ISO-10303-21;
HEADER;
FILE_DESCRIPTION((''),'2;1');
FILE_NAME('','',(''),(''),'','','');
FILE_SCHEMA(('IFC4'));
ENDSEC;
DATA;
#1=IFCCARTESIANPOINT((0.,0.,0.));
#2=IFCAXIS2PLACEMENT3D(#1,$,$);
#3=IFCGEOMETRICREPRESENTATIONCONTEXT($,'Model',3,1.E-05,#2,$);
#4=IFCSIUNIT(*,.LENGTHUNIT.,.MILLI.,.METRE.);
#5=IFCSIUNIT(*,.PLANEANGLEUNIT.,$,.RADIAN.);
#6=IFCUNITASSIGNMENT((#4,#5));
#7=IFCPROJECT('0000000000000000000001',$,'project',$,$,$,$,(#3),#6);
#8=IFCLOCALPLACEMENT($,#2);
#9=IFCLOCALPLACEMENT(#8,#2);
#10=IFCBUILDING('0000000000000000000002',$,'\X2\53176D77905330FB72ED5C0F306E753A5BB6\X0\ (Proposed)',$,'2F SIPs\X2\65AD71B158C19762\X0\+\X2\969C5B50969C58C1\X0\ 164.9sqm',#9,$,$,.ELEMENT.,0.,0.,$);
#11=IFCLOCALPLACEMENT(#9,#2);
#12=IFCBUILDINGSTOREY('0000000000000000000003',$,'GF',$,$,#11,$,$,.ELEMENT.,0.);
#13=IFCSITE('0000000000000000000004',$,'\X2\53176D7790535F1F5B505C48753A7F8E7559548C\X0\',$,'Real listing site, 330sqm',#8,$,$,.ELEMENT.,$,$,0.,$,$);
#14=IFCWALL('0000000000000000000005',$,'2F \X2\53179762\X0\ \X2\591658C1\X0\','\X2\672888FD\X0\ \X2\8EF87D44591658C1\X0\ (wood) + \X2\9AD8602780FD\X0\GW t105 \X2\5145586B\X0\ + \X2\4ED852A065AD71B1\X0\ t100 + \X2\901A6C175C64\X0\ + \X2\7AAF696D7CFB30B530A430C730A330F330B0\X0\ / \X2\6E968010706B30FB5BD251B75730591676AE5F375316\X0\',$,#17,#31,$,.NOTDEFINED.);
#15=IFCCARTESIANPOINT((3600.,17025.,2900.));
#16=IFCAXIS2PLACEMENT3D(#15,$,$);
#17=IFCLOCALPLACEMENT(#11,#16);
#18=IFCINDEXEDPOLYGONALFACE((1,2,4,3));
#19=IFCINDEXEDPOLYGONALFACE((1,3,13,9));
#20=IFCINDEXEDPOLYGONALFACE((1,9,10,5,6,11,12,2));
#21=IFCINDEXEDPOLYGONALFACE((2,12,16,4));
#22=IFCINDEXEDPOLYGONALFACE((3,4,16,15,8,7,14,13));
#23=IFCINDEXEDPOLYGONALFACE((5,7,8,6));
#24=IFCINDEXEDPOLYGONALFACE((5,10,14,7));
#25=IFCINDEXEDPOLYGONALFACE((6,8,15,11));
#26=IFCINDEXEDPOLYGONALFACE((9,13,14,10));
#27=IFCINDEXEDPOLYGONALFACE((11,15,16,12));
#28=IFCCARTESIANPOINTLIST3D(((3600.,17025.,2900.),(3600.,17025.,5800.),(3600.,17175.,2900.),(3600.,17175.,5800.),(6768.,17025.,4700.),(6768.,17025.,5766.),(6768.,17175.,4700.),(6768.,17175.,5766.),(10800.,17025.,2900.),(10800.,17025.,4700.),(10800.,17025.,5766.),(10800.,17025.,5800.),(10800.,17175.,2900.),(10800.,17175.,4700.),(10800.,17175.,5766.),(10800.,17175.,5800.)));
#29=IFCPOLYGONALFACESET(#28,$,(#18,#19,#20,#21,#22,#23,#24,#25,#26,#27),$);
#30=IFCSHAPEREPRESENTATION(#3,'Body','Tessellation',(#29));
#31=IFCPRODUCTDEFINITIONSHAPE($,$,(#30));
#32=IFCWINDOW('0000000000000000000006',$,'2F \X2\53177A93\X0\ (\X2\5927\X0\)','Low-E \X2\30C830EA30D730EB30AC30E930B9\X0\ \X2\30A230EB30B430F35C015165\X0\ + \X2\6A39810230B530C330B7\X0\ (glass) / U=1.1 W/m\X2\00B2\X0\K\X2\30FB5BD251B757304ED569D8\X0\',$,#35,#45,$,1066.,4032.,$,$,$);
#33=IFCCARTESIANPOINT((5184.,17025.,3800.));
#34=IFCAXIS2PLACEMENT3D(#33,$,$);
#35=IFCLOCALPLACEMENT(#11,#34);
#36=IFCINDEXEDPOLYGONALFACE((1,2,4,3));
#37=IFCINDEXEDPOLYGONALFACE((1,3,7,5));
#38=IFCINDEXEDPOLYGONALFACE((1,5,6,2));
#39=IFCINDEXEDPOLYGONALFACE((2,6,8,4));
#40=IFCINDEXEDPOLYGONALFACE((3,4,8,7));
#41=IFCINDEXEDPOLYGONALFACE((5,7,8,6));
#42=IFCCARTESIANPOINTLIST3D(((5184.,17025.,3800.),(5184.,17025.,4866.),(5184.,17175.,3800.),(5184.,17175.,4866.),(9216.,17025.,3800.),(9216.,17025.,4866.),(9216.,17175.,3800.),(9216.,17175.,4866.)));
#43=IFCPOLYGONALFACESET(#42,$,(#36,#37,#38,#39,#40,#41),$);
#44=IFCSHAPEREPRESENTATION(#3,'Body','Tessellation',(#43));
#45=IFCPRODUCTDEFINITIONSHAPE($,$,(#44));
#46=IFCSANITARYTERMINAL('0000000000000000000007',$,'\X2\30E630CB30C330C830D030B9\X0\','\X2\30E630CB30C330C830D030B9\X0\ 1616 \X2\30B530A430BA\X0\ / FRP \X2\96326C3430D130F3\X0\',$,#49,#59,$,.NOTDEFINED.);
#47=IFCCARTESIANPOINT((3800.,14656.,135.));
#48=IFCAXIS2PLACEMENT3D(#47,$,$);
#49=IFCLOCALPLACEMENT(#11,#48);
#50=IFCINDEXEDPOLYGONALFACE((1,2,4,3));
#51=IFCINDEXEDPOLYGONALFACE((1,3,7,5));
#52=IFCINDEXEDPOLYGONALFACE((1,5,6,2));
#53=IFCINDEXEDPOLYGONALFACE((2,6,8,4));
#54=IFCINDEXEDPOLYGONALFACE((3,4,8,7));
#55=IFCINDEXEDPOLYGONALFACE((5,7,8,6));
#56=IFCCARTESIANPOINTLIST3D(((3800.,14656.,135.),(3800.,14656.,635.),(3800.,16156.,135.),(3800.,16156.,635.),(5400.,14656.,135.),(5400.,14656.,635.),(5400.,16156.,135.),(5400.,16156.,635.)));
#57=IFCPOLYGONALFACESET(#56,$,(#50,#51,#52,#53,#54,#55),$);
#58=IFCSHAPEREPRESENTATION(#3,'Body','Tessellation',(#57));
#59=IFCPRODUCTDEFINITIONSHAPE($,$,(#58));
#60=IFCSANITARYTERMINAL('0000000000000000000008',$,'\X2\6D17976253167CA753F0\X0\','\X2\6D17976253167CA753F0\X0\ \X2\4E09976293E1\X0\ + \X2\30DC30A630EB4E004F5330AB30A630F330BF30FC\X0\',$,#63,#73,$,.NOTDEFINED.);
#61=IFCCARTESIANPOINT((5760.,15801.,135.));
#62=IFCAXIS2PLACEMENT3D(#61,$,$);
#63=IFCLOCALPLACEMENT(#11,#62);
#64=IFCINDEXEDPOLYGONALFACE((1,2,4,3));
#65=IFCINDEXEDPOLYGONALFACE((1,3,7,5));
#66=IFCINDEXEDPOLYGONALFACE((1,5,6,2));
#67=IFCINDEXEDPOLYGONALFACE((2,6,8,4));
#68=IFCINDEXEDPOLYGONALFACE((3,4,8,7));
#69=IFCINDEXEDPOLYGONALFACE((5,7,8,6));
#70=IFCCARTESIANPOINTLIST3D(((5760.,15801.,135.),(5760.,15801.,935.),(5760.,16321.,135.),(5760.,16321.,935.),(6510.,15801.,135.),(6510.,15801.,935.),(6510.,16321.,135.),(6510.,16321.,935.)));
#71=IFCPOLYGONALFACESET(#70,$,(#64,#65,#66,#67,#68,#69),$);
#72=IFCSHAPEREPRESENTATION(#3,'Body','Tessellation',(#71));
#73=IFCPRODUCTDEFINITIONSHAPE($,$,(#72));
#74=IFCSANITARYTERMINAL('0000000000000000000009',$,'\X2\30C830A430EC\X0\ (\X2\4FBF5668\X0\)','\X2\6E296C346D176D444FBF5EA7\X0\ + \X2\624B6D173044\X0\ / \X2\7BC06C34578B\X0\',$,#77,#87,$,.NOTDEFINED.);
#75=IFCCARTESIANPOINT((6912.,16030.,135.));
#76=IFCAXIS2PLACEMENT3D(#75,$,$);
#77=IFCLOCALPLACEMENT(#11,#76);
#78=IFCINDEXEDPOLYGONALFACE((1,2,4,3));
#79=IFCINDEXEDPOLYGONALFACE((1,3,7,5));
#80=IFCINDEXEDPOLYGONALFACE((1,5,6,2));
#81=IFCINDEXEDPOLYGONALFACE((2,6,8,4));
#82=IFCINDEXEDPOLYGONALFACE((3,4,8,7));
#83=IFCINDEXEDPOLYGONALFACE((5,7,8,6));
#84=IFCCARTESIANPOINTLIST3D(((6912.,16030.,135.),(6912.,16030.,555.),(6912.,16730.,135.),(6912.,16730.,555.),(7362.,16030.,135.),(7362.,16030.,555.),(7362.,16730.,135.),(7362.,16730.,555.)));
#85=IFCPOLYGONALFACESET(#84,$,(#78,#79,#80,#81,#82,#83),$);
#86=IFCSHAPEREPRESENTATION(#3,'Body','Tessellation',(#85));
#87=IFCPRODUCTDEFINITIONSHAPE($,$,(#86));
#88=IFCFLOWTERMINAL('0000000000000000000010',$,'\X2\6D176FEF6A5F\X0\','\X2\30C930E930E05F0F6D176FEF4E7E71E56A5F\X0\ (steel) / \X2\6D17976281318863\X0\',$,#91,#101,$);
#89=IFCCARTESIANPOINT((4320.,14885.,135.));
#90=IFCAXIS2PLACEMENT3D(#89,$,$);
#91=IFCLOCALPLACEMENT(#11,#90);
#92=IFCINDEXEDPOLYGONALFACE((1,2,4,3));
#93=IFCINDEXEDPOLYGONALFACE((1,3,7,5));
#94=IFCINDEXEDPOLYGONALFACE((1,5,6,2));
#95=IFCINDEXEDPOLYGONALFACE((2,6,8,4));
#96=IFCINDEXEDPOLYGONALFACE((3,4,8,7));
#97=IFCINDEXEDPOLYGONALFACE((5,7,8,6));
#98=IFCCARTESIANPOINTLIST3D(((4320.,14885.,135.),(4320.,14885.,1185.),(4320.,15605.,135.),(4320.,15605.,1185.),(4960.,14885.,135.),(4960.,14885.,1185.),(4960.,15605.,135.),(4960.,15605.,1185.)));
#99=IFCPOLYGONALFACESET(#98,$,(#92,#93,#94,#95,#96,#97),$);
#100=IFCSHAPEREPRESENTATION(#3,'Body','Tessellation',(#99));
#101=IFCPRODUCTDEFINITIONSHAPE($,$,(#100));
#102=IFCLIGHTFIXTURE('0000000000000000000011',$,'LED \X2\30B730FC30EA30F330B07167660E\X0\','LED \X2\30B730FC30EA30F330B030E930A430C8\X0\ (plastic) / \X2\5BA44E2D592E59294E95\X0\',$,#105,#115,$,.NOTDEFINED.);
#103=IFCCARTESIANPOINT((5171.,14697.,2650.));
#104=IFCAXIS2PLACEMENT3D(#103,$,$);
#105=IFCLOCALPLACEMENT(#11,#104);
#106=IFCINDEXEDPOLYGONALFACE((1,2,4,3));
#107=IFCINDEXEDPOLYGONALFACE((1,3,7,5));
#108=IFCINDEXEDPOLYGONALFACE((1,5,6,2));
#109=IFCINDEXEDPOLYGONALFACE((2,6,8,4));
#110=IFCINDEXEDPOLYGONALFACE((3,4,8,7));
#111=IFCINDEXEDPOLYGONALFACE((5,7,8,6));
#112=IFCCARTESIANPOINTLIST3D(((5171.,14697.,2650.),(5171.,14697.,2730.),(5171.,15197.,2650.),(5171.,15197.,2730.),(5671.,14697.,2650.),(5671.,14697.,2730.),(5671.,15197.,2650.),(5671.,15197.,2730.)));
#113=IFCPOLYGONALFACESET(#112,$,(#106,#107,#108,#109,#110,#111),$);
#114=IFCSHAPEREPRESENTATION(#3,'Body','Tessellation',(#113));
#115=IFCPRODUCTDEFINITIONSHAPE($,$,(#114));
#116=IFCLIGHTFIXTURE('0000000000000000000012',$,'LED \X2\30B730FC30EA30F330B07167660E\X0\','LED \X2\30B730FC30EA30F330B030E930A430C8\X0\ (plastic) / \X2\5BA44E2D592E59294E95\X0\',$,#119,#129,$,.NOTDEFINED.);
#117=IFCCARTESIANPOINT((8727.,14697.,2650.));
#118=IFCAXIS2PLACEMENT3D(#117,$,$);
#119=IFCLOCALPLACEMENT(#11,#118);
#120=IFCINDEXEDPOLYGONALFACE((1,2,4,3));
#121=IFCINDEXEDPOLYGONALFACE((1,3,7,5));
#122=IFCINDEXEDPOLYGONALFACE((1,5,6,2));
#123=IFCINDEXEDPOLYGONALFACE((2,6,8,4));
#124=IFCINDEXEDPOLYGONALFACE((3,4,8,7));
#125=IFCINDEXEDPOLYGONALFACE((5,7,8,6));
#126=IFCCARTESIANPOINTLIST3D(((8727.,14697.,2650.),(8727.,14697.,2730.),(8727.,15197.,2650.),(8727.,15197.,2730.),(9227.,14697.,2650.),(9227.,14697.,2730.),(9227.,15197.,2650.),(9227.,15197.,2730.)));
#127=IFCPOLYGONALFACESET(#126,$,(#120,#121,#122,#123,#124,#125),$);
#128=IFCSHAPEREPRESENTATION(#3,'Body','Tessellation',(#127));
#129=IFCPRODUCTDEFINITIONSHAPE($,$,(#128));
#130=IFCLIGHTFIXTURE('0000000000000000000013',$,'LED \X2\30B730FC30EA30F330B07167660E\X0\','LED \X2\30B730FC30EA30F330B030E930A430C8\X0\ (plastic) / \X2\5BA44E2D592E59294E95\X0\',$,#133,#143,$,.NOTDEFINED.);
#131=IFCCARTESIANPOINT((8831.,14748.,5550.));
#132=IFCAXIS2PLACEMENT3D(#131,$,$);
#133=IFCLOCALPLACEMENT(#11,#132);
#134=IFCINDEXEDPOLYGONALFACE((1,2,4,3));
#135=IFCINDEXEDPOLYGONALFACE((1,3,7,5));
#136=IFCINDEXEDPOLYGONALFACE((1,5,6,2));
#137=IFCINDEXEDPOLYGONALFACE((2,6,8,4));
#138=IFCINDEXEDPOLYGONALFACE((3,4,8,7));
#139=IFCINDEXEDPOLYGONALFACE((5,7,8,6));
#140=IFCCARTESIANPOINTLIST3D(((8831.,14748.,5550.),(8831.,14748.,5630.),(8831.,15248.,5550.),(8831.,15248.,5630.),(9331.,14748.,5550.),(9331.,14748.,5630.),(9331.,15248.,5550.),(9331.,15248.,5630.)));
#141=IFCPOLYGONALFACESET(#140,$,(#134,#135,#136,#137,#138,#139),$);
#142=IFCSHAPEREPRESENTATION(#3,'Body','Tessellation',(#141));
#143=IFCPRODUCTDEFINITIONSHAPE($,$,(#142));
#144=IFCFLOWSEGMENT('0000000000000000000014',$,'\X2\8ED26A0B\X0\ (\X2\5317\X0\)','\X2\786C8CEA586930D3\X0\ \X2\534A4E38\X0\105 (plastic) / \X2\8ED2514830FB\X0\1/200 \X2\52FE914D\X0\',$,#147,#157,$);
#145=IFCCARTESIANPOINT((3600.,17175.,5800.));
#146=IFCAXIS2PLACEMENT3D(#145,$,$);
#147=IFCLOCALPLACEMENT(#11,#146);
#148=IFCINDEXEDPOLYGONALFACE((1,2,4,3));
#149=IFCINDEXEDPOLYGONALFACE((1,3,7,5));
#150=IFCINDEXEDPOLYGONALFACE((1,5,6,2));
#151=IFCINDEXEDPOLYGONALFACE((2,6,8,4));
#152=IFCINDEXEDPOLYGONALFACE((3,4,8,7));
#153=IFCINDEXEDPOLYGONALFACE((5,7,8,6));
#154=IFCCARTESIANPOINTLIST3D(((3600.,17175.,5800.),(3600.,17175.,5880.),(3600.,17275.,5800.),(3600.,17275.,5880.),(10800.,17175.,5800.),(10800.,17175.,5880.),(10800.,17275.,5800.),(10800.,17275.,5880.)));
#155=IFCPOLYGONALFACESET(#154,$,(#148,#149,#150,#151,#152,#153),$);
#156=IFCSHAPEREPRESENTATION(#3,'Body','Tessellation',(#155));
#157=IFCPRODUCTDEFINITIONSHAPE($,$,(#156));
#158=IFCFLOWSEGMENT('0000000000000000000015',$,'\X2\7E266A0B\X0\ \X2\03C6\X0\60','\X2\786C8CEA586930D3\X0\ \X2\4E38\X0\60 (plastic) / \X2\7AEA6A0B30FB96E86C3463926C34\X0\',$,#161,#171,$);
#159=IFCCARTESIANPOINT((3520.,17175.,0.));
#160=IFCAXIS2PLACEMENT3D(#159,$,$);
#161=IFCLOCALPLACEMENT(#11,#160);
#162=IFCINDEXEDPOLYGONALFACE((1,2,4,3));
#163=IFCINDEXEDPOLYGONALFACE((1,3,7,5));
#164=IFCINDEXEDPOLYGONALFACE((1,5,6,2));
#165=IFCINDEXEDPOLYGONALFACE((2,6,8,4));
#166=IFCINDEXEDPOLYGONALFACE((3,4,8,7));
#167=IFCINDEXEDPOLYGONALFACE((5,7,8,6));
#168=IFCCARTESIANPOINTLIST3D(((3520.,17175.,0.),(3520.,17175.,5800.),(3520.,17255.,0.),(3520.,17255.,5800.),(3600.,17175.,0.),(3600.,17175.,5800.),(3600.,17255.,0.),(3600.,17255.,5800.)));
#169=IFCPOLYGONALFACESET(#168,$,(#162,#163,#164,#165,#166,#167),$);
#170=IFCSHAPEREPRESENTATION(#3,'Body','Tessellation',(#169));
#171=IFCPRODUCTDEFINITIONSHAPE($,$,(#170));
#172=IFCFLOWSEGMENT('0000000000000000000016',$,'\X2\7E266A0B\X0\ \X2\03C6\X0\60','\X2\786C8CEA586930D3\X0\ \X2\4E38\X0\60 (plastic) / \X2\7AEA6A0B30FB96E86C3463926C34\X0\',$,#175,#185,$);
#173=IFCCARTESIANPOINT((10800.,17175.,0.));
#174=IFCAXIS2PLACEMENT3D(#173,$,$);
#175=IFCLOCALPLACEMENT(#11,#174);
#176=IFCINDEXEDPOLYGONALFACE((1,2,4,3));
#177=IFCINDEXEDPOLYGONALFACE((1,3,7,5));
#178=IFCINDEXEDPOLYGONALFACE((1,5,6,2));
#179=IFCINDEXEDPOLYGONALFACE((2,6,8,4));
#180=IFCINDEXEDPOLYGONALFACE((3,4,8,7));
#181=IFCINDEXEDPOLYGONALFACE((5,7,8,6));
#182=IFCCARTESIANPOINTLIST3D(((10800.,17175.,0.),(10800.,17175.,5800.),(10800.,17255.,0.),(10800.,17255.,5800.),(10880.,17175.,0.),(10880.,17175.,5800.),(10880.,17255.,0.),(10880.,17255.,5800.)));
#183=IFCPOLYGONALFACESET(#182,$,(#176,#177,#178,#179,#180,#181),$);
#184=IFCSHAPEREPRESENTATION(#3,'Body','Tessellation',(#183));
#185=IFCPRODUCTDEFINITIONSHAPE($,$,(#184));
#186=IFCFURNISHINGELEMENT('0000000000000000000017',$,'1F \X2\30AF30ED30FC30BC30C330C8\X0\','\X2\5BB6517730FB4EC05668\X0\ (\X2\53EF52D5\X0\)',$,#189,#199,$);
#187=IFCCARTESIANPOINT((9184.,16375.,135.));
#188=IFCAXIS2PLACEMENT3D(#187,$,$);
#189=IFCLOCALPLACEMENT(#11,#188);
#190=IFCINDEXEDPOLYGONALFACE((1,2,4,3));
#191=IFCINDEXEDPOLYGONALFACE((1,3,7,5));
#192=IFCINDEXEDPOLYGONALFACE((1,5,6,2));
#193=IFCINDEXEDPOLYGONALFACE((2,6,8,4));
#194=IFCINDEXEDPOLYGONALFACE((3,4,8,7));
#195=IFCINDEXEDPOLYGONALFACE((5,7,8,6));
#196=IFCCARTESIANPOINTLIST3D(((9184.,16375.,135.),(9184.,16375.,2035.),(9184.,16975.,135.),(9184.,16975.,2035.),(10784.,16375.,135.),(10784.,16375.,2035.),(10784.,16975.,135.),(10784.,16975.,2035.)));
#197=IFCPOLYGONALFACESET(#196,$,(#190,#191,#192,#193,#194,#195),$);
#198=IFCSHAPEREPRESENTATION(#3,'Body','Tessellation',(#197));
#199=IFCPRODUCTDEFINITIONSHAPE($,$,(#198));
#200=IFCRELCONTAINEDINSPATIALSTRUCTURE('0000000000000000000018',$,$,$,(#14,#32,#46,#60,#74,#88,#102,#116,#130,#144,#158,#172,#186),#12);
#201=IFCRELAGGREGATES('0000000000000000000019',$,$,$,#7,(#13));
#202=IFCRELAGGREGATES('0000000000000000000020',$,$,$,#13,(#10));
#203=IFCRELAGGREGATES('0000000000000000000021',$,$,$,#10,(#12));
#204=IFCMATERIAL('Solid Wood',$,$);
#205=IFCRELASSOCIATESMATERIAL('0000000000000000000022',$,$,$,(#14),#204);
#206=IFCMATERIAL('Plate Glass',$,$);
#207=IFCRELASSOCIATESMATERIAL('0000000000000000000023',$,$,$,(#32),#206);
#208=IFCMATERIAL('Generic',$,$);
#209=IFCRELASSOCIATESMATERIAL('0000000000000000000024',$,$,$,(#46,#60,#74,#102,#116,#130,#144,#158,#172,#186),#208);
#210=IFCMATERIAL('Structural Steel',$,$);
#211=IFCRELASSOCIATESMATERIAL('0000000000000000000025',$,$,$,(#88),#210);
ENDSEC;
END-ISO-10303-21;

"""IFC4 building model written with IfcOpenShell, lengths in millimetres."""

from ifc_helpers import new_model, si_unit, frame, frame_2d, origin, place, context, project, spatial, rectangle, extrude, material, element, fill, save


model = new_model("IFC4")

# Units and contexts
model_context = context("Model", 3, precision=1e-05, world=origin())
ifc_project = project(units=[si_unit("LENGTHUNIT", "METRE", prefix="MILLI"), si_unit("PLANEANGLEUNIT", "RADIAN")], contexts=[model_context])

# Site, building, storey
site_placement = place(None, origin())
site = spatial("IfcSite", under=ifc_project, at=site_placement, Name="北海道弟子屈町美留和", ObjectType="Real listing site, 330sqm", CompositionType="ELEMENT", RefElevation=0.0)
building_placement = place(site_placement, origin())
building = spatial("IfcBuilding", under=site, at=building_placement, Name="北海道・狭小の町家 (Proposed)", ObjectType="2F SIPs断熱壁面+障子障壁 164.9sqm", CompositionType="ELEMENT", ElevationOfRefHeight=0.0, ElevationOfTerrain=0.0)
storey_placement = place(building_placement, origin())
storey = spatial("IfcBuildingStorey", under=building, at=storey_placement, Name="GF", CompositionType="ELEMENT", Elevation=0.0)

# Shared definitions
ifc_material_1 = material(Name="Solid Wood")

# Shared definitions
ifc_material_2 = material(Name="Plate Glass")

# Wall, opening, window
wall_1_placement = place(storey_placement, frame((3600.0, 17025.0, 2900.0)))
wall_1 = element("IfcWall", 1, at=wall_1_placement, inside=storey, material=ifc_material_1, Name="2F 北面 外壁", Description="木製 軸組外壁 (wood) + 高性能GW t105 充填 + 付加断熱 t100 + 通気層 + 窯業系サイディング / 準耐火・寒冷地外皮強化", PredefinedType="NOTDEFINED", context=model_context, shape_type="SweptSolid", body=[
    extrude(rectangle(XDim=7200.0, YDim=150.0, at=frame_2d((3600.0, 75.0))), frame((3600.0, 17025.0, 2900.0)), (0.0, 0.0, 1.0), 2900.0),
])
opening_1_placement = place(storey_placement, frame((5184.0, 17025.0, 3800.0)))
opening_1 = element("IfcOpeningElement", 2, at=opening_1_placement, cuts=wall_1, PredefinedType="NOTDEFINED", context=model_context, shape_type="SweptSolid", body=[
    extrude(rectangle(XDim=4032.0, YDim=150.0, at=frame_2d((2016.0, 75.0))), frame((5184.0, 17025.0, 3800.0)), (0.0, 0.0, 1.0), 1066.0),
])
window_1_placement = place(storey_placement, frame((5184.0, 17025.0, 3800.0)))
window_1 = element("IfcWindow", 3, at=window_1_placement, inside=storey, material=ifc_material_2, Name="2F 北窓 (大)", Description="Low-E トリプルガラス アルゴン封入 + 樹脂サッシ (glass) / U=1.1 W/m²K・寒冷地仕様", OverallHeight=1066.0, OverallWidth=4032.0, context=model_context, shape_type="SweptSolid", body=[
    extrude(rectangle(XDim=4032.0, YDim=150.0, at=frame_2d((2016.0, 75.0))), frame((5184.0, 17025.0, 3800.0)), (0.0, 0.0, 1.0), 1066.0),
])
fill(opening_1, window_1)

# Sanitary terminals
ifc_material_3 = material(Name="Generic")
sanitary_terminal_1_placement = place(storey_placement, frame((3800.0, 14656.0, 135.0)))
element("IfcSanitaryTerminal", 4, at=sanitary_terminal_1_placement, inside=storey, material=ifc_material_3, Name="ユニットバス", Description="ユニットバス 1616 サイズ / FRP 防水パン", PredefinedType="NOTDEFINED", context=model_context, shape_type="SweptSolid", body=[
    extrude(rectangle(XDim=1600.0, YDim=1500.0, at=frame_2d((800.0, 750.0))), frame((3800.0, 14656.0, 135.0)), (0.0, 0.0, 1.0), 500.0),
])
sanitary_terminal_2_placement = place(storey_placement, frame((5760.0, 15801.0, 135.0)))
element("IfcSanitaryTerminal", 5, at=sanitary_terminal_2_placement, inside=storey, material=ifc_material_3, Name="洗面化粧台", Description="洗面化粧台 三面鏡 + ボウル一体カウンター", PredefinedType="NOTDEFINED", context=model_context, shape_type="SweptSolid", body=[
    extrude(rectangle(XDim=750.0, YDim=520.0, at=frame_2d((375.0, 260.0))), frame((5760.0, 15801.0, 135.0)), (0.0, 0.0, 1.0), 800.0),
])
sanitary_terminal_3_placement = place(storey_placement, frame((6912.0, 16030.0, 135.0)))
element("IfcSanitaryTerminal", 6, at=sanitary_terminal_3_placement, inside=storey, material=ifc_material_3, Name="トイレ (便器)", Description="温水洗浄便座 + 手洗い / 節水型", PredefinedType="NOTDEFINED", context=model_context, shape_type="SweptSolid", body=[
    extrude(rectangle(XDim=450.0, YDim=700.0, at=frame_2d((225.0, 350.0))), frame((6912.0, 16030.0, 135.0)), (0.0, 0.0, 1.0), 420.0),
])

# Flow terminal
ifc_material_4 = material(Name="Structural Steel")
flow_terminal_placement = place(storey_placement, frame((4320.0, 14885.0, 135.0)))
element("IfcFlowTerminal", 7, at=flow_terminal_placement, inside=storey, material=ifc_material_4, Name="洗濯機", Description="ドラム式洗濯乾燥機 (steel) / 洗面脱衣", context=model_context, shape_type="SweptSolid", body=[
    extrude(rectangle(XDim=640.0, YDim=720.0, at=frame_2d((320.0, 360.0))), frame((4320.0, 14885.0, 135.0)), (0.0, 0.0, 1.0), 1050.0),
])

# Light fixtures
light_fixture_1_placement = place(storey_placement, frame((5171.0, 14697.0, 2650.0)))
element("IfcLightFixture", 8, at=light_fixture_1_placement, inside=storey, material=ifc_material_3, Name="LED シーリング照明", Description="LED シーリングライト (plastic) / 室中央天井", PredefinedType="NOTDEFINED", context=model_context, shape_type="SweptSolid", body=[
    extrude(rectangle(XDim=500.0, YDim=500.0, at=frame_2d((250.0, 250.0))), frame((5171.0, 14697.0, 2650.0)), (0.0, 0.0, 1.0), 80.0),
])
light_fixture_2_placement = place(storey_placement, frame((8727.0, 14697.0, 2650.0)))
element("IfcLightFixture", 9, at=light_fixture_2_placement, inside=storey, material=ifc_material_3, Name="LED シーリング照明", Description="LED シーリングライト (plastic) / 室中央天井", PredefinedType="NOTDEFINED", context=model_context, shape_type="SweptSolid", body=[
    extrude(rectangle(XDim=500.0, YDim=500.0, at=frame_2d((250.0, 250.0))), frame((8727.0, 14697.0, 2650.0)), (0.0, 0.0, 1.0), 80.0),
])
light_fixture_3_placement = place(storey_placement, frame((8831.0, 14748.0, 5550.0)))
element("IfcLightFixture", 10, at=light_fixture_3_placement, inside=storey, material=ifc_material_3, Name="LED シーリング照明", Description="LED シーリングライト (plastic) / 室中央天井", PredefinedType="NOTDEFINED", context=model_context, shape_type="SweptSolid", body=[
    extrude(rectangle(XDim=500.0, YDim=500.0, at=frame_2d((250.0, 250.0))), frame((8831.0, 14748.0, 5550.0)), (0.0, 0.0, 1.0), 80.0),
])

# Flow segments
flow_segment_1_placement = place(storey_placement, frame((3600.0, 17175.0, 5800.0)))
element("IfcFlowSegment", 11, at=flow_segment_1_placement, inside=storey, material=ifc_material_3, Name="軒樋 (北)", Description="硬質塩ビ 半丸105 (plastic) / 軒先・1/200 勾配", context=model_context, shape_type="SweptSolid", body=[
    extrude(rectangle(XDim=7200.0, YDim=100.0, at=frame_2d((3600.0, 50.0))), frame((3600.0, 17175.0, 5800.0)), (0.0, 0.0, 1.0), 80.0),
])
flow_segment_2_placement = place(storey_placement, frame((3520.0, 17175.0, 0.0)))
element("IfcFlowSegment", 12, at=flow_segment_2_placement, inside=storey, material=ifc_material_3, Name="縦樋 φ60", Description="硬質塩ビ 丸60 (plastic) / 竪樋・雨水排水", context=model_context, shape_type="SweptSolid", body=[
    extrude(rectangle(XDim=80.0, YDim=80.0, at=frame_2d((40.0, 40.0))), frame((3520.0, 17175.0, 0.0)), (0.0, 0.0, 1.0), 5800.0),
])
flow_segment_3_placement = place(storey_placement, frame((10800.0, 17175.0, 0.0)))
element("IfcFlowSegment", 13, at=flow_segment_3_placement, inside=storey, material=ifc_material_3, Name="縦樋 φ60", Description="硬質塩ビ 丸60 (plastic) / 竪樋・雨水排水", context=model_context, shape_type="SweptSolid", body=[
    extrude(rectangle(XDim=80.0, YDim=80.0, at=frame_2d((40.0, 40.0))), frame((10800.0, 17175.0, 0.0)), (0.0, 0.0, 1.0), 5800.0),
])

# Furnishing element
furnishing_1_placement = place(storey_placement, frame((9184.0, 16375.0, 135.0)))
element("IfcFurnishingElement", 14, at=furnishing_1_placement, inside=storey, material=ifc_material_3, Name="1F クローゼット", Description="家具・什器 (可動)", context=model_context, shape_type="SweptSolid", body=[
    extrude(rectangle(XDim=1600.0, YDim=600.0, at=frame_2d((800.0, 300.0))), frame((9184.0, 16375.0, 135.0)), (0.0, 0.0, 1.0), 1900.0),
])

save(model, "model.ifc")
